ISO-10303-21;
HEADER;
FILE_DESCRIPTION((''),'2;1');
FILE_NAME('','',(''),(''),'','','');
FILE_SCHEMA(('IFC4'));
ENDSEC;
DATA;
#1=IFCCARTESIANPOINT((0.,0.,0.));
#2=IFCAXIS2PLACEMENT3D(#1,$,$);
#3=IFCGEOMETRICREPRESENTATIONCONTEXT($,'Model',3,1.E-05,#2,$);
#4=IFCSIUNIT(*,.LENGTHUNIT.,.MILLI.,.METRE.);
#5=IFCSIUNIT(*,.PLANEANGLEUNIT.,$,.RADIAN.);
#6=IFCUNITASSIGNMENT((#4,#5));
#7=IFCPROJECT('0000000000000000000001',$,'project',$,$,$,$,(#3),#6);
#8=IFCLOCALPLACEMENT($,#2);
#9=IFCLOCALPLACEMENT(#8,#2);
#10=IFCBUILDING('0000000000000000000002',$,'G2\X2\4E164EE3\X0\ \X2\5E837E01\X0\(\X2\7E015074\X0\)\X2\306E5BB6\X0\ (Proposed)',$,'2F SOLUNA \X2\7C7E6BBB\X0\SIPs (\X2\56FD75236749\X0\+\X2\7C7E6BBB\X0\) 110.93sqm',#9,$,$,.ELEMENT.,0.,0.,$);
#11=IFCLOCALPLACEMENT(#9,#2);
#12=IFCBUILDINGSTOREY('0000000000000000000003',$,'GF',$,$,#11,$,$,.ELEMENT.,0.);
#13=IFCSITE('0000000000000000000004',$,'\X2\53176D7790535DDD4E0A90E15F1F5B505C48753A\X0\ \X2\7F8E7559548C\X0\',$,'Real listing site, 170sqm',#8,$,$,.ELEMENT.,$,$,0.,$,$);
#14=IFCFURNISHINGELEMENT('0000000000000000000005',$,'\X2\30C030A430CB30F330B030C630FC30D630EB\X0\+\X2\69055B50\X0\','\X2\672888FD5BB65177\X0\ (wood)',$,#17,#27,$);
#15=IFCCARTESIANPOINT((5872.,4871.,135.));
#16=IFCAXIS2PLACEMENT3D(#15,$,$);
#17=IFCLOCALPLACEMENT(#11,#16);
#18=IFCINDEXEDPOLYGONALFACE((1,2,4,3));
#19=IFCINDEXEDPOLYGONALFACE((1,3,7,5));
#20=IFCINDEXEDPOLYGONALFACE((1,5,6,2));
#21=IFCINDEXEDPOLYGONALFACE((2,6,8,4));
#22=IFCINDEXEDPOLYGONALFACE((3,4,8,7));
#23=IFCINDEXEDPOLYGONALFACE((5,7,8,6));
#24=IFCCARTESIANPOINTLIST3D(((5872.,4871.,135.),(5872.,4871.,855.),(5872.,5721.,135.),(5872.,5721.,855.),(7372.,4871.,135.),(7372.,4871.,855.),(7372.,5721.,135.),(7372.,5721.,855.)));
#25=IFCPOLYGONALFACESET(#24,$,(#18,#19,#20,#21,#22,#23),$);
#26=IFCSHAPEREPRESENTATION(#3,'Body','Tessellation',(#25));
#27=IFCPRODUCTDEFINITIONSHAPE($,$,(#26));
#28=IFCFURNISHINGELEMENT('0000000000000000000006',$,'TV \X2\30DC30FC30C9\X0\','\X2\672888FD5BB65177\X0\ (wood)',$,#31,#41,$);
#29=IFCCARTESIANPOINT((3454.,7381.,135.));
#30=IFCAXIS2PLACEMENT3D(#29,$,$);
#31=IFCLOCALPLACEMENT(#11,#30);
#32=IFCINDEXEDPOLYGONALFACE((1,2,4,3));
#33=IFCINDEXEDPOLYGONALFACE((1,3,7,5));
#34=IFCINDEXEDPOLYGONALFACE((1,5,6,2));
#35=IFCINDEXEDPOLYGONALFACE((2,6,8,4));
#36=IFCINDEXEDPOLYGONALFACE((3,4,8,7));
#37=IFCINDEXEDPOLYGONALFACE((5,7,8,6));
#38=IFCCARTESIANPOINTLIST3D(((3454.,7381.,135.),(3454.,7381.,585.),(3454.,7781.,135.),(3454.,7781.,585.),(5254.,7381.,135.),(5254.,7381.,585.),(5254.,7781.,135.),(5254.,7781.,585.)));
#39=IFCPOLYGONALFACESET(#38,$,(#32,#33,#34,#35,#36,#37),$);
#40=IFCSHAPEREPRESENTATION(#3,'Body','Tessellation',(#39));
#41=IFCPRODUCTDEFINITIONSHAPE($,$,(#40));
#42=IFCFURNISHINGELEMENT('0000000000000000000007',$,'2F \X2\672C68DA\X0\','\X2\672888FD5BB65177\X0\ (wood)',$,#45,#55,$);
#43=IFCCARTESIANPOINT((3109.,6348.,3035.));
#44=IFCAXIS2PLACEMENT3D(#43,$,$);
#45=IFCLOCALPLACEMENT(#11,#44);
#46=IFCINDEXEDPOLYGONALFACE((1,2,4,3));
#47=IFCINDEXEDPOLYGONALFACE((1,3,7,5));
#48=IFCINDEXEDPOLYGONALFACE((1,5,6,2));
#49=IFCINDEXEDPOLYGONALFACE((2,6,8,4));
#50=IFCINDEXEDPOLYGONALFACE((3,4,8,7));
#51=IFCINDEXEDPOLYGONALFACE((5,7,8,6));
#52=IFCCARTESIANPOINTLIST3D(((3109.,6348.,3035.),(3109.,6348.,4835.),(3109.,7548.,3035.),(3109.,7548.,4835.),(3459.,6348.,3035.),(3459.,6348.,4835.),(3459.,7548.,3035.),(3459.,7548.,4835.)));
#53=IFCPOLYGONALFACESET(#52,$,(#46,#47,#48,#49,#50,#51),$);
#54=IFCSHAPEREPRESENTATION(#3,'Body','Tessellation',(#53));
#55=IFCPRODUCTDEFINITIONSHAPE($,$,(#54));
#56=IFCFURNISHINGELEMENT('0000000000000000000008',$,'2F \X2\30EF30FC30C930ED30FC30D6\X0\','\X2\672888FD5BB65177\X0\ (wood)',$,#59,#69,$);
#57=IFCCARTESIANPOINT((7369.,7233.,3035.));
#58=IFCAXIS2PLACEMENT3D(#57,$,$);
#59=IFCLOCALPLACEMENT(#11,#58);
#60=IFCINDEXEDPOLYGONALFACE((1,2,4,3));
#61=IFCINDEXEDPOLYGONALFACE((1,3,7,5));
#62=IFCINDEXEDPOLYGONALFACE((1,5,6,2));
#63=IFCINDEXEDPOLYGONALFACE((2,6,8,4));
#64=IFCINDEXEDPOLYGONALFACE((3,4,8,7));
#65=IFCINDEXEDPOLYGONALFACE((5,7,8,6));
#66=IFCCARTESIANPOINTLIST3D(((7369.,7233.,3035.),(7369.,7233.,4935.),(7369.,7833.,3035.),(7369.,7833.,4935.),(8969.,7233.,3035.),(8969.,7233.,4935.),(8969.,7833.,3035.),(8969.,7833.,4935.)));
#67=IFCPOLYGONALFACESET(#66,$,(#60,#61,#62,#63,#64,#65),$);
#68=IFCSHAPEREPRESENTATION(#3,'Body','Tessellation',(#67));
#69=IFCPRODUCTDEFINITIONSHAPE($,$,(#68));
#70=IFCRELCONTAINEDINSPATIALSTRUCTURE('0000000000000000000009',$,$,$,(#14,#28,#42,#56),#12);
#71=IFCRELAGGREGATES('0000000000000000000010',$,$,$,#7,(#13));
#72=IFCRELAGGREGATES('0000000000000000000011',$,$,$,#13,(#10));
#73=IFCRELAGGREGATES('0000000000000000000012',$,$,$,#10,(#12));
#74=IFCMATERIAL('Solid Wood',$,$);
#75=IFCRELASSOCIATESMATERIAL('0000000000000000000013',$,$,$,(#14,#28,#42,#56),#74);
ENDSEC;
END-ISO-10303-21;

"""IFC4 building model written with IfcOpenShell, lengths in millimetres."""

from ifc_helpers import new_model, si_unit, frame, frame_2d, origin, place, context, project, spatial, rectangle, extrude, material, element, save


model = new_model("IFC4")

# Units and contexts
model_context = context("Model", 3, precision=1e-05, world=origin())
ifc_project = project(units=[si_unit("LENGTHUNIT", "METRE", prefix="MILLI"), si_unit("PLANEANGLEUNIT", "RADIAN")], contexts=[model_context])

# Site, building, storey
site_placement = place(None, origin())
site = spatial("IfcSite", under=ifc_project, at=site_placement, Name="北海道川上郡弟子屈町 美留和", ObjectType="Real listing site, 170sqm", CompositionType="ELEMENT", RefElevation=0.0)
building_placement = place(site_placement, origin())
building = spatial("IfcBuilding", under=site, at=building_placement, Name="G2世代 広縁(縁側)の家 (Proposed)", ObjectType="2F SOLUNA 籾殻SIPs (国産杉+籾殻) 110.93sqm", CompositionType="ELEMENT", ElevationOfRefHeight=0.0, ElevationOfTerrain=0.0)
storey_placement = place(building_placement, origin())
storey = spatial("IfcBuildingStorey", under=building, at=storey_placement, Name="GF", CompositionType="ELEMENT", Elevation=0.0)

# Shared definitions
ifc_material_1 = material(Name="Solid Wood")

# Furnishing elements
furnishing_1_placement = place(storey_placement, frame((5872.0, 4871.0, 135.0)))
element("IfcFurnishingElement", 1, at=furnishing_1_placement, inside=storey, material=ifc_material_1, Name="ダイニングテーブル+椅子", Description="木製家具 (wood)", context=model_context, shape_type="SweptSolid", body=[
    extrude(rectangle(XDim=1500.0, YDim=850.0, at=frame_2d((750.0, 425.0))), frame((5872.0, 4871.0, 135.0)), (0.0, 0.0, 1.0), 720.0),
])
furnishing_2_placement = place(storey_placement, frame((3454.0, 7381.0, 135.0)))
element("IfcFurnishingElement", 2, at=furnishing_2_placement, inside=storey, material=ifc_material_1, Name="TV ボード", Description="木製家具 (wood)", context=model_context, shape_type="SweptSolid", body=[
    extrude(rectangle(XDim=1800.0, YDim=400.0, at=frame_2d((900.0, 200.0))), frame((3454.0, 7381.0, 135.0)), (0.0, 0.0, 1.0), 450.0),
])
furnishing_3_placement = place(storey_placement, frame((3109.0, 6348.0, 3035.0)))
element("IfcFurnishingElement", 3, at=furnishing_3_placement, inside=storey, material=ifc_material_1, Name="2F 本棚", Description="木製家具 (wood)", context=model_context, shape_type="SweptSolid", body=[
    extrude(rectangle(XDim=350.0, YDim=1200.0, at=frame_2d((175.0, 600.0))), frame((3109.0, 6348.0, 3035.0)), (0.0, 0.0, 1.0), 1800.0),
])
furnishing_4_placement = place(storey_placement, frame((7369.0, 7233.0, 3035.0)))
element("IfcFurnishingElement", 4, at=furnishing_4_placement, inside=storey, material=ifc_material_1, Name="2F ワードローブ", Description="木製家具 (wood)", context=model_context, shape_type="SweptSolid", body=[
    extrude(rectangle(XDim=1600.0, YDim=600.0, at=frame_2d((800.0, 300.0))), frame((7369.0, 7233.0, 3035.0)), (0.0, 0.0, 1.0), 1900.0),
])

save(model, "model.ifc")
